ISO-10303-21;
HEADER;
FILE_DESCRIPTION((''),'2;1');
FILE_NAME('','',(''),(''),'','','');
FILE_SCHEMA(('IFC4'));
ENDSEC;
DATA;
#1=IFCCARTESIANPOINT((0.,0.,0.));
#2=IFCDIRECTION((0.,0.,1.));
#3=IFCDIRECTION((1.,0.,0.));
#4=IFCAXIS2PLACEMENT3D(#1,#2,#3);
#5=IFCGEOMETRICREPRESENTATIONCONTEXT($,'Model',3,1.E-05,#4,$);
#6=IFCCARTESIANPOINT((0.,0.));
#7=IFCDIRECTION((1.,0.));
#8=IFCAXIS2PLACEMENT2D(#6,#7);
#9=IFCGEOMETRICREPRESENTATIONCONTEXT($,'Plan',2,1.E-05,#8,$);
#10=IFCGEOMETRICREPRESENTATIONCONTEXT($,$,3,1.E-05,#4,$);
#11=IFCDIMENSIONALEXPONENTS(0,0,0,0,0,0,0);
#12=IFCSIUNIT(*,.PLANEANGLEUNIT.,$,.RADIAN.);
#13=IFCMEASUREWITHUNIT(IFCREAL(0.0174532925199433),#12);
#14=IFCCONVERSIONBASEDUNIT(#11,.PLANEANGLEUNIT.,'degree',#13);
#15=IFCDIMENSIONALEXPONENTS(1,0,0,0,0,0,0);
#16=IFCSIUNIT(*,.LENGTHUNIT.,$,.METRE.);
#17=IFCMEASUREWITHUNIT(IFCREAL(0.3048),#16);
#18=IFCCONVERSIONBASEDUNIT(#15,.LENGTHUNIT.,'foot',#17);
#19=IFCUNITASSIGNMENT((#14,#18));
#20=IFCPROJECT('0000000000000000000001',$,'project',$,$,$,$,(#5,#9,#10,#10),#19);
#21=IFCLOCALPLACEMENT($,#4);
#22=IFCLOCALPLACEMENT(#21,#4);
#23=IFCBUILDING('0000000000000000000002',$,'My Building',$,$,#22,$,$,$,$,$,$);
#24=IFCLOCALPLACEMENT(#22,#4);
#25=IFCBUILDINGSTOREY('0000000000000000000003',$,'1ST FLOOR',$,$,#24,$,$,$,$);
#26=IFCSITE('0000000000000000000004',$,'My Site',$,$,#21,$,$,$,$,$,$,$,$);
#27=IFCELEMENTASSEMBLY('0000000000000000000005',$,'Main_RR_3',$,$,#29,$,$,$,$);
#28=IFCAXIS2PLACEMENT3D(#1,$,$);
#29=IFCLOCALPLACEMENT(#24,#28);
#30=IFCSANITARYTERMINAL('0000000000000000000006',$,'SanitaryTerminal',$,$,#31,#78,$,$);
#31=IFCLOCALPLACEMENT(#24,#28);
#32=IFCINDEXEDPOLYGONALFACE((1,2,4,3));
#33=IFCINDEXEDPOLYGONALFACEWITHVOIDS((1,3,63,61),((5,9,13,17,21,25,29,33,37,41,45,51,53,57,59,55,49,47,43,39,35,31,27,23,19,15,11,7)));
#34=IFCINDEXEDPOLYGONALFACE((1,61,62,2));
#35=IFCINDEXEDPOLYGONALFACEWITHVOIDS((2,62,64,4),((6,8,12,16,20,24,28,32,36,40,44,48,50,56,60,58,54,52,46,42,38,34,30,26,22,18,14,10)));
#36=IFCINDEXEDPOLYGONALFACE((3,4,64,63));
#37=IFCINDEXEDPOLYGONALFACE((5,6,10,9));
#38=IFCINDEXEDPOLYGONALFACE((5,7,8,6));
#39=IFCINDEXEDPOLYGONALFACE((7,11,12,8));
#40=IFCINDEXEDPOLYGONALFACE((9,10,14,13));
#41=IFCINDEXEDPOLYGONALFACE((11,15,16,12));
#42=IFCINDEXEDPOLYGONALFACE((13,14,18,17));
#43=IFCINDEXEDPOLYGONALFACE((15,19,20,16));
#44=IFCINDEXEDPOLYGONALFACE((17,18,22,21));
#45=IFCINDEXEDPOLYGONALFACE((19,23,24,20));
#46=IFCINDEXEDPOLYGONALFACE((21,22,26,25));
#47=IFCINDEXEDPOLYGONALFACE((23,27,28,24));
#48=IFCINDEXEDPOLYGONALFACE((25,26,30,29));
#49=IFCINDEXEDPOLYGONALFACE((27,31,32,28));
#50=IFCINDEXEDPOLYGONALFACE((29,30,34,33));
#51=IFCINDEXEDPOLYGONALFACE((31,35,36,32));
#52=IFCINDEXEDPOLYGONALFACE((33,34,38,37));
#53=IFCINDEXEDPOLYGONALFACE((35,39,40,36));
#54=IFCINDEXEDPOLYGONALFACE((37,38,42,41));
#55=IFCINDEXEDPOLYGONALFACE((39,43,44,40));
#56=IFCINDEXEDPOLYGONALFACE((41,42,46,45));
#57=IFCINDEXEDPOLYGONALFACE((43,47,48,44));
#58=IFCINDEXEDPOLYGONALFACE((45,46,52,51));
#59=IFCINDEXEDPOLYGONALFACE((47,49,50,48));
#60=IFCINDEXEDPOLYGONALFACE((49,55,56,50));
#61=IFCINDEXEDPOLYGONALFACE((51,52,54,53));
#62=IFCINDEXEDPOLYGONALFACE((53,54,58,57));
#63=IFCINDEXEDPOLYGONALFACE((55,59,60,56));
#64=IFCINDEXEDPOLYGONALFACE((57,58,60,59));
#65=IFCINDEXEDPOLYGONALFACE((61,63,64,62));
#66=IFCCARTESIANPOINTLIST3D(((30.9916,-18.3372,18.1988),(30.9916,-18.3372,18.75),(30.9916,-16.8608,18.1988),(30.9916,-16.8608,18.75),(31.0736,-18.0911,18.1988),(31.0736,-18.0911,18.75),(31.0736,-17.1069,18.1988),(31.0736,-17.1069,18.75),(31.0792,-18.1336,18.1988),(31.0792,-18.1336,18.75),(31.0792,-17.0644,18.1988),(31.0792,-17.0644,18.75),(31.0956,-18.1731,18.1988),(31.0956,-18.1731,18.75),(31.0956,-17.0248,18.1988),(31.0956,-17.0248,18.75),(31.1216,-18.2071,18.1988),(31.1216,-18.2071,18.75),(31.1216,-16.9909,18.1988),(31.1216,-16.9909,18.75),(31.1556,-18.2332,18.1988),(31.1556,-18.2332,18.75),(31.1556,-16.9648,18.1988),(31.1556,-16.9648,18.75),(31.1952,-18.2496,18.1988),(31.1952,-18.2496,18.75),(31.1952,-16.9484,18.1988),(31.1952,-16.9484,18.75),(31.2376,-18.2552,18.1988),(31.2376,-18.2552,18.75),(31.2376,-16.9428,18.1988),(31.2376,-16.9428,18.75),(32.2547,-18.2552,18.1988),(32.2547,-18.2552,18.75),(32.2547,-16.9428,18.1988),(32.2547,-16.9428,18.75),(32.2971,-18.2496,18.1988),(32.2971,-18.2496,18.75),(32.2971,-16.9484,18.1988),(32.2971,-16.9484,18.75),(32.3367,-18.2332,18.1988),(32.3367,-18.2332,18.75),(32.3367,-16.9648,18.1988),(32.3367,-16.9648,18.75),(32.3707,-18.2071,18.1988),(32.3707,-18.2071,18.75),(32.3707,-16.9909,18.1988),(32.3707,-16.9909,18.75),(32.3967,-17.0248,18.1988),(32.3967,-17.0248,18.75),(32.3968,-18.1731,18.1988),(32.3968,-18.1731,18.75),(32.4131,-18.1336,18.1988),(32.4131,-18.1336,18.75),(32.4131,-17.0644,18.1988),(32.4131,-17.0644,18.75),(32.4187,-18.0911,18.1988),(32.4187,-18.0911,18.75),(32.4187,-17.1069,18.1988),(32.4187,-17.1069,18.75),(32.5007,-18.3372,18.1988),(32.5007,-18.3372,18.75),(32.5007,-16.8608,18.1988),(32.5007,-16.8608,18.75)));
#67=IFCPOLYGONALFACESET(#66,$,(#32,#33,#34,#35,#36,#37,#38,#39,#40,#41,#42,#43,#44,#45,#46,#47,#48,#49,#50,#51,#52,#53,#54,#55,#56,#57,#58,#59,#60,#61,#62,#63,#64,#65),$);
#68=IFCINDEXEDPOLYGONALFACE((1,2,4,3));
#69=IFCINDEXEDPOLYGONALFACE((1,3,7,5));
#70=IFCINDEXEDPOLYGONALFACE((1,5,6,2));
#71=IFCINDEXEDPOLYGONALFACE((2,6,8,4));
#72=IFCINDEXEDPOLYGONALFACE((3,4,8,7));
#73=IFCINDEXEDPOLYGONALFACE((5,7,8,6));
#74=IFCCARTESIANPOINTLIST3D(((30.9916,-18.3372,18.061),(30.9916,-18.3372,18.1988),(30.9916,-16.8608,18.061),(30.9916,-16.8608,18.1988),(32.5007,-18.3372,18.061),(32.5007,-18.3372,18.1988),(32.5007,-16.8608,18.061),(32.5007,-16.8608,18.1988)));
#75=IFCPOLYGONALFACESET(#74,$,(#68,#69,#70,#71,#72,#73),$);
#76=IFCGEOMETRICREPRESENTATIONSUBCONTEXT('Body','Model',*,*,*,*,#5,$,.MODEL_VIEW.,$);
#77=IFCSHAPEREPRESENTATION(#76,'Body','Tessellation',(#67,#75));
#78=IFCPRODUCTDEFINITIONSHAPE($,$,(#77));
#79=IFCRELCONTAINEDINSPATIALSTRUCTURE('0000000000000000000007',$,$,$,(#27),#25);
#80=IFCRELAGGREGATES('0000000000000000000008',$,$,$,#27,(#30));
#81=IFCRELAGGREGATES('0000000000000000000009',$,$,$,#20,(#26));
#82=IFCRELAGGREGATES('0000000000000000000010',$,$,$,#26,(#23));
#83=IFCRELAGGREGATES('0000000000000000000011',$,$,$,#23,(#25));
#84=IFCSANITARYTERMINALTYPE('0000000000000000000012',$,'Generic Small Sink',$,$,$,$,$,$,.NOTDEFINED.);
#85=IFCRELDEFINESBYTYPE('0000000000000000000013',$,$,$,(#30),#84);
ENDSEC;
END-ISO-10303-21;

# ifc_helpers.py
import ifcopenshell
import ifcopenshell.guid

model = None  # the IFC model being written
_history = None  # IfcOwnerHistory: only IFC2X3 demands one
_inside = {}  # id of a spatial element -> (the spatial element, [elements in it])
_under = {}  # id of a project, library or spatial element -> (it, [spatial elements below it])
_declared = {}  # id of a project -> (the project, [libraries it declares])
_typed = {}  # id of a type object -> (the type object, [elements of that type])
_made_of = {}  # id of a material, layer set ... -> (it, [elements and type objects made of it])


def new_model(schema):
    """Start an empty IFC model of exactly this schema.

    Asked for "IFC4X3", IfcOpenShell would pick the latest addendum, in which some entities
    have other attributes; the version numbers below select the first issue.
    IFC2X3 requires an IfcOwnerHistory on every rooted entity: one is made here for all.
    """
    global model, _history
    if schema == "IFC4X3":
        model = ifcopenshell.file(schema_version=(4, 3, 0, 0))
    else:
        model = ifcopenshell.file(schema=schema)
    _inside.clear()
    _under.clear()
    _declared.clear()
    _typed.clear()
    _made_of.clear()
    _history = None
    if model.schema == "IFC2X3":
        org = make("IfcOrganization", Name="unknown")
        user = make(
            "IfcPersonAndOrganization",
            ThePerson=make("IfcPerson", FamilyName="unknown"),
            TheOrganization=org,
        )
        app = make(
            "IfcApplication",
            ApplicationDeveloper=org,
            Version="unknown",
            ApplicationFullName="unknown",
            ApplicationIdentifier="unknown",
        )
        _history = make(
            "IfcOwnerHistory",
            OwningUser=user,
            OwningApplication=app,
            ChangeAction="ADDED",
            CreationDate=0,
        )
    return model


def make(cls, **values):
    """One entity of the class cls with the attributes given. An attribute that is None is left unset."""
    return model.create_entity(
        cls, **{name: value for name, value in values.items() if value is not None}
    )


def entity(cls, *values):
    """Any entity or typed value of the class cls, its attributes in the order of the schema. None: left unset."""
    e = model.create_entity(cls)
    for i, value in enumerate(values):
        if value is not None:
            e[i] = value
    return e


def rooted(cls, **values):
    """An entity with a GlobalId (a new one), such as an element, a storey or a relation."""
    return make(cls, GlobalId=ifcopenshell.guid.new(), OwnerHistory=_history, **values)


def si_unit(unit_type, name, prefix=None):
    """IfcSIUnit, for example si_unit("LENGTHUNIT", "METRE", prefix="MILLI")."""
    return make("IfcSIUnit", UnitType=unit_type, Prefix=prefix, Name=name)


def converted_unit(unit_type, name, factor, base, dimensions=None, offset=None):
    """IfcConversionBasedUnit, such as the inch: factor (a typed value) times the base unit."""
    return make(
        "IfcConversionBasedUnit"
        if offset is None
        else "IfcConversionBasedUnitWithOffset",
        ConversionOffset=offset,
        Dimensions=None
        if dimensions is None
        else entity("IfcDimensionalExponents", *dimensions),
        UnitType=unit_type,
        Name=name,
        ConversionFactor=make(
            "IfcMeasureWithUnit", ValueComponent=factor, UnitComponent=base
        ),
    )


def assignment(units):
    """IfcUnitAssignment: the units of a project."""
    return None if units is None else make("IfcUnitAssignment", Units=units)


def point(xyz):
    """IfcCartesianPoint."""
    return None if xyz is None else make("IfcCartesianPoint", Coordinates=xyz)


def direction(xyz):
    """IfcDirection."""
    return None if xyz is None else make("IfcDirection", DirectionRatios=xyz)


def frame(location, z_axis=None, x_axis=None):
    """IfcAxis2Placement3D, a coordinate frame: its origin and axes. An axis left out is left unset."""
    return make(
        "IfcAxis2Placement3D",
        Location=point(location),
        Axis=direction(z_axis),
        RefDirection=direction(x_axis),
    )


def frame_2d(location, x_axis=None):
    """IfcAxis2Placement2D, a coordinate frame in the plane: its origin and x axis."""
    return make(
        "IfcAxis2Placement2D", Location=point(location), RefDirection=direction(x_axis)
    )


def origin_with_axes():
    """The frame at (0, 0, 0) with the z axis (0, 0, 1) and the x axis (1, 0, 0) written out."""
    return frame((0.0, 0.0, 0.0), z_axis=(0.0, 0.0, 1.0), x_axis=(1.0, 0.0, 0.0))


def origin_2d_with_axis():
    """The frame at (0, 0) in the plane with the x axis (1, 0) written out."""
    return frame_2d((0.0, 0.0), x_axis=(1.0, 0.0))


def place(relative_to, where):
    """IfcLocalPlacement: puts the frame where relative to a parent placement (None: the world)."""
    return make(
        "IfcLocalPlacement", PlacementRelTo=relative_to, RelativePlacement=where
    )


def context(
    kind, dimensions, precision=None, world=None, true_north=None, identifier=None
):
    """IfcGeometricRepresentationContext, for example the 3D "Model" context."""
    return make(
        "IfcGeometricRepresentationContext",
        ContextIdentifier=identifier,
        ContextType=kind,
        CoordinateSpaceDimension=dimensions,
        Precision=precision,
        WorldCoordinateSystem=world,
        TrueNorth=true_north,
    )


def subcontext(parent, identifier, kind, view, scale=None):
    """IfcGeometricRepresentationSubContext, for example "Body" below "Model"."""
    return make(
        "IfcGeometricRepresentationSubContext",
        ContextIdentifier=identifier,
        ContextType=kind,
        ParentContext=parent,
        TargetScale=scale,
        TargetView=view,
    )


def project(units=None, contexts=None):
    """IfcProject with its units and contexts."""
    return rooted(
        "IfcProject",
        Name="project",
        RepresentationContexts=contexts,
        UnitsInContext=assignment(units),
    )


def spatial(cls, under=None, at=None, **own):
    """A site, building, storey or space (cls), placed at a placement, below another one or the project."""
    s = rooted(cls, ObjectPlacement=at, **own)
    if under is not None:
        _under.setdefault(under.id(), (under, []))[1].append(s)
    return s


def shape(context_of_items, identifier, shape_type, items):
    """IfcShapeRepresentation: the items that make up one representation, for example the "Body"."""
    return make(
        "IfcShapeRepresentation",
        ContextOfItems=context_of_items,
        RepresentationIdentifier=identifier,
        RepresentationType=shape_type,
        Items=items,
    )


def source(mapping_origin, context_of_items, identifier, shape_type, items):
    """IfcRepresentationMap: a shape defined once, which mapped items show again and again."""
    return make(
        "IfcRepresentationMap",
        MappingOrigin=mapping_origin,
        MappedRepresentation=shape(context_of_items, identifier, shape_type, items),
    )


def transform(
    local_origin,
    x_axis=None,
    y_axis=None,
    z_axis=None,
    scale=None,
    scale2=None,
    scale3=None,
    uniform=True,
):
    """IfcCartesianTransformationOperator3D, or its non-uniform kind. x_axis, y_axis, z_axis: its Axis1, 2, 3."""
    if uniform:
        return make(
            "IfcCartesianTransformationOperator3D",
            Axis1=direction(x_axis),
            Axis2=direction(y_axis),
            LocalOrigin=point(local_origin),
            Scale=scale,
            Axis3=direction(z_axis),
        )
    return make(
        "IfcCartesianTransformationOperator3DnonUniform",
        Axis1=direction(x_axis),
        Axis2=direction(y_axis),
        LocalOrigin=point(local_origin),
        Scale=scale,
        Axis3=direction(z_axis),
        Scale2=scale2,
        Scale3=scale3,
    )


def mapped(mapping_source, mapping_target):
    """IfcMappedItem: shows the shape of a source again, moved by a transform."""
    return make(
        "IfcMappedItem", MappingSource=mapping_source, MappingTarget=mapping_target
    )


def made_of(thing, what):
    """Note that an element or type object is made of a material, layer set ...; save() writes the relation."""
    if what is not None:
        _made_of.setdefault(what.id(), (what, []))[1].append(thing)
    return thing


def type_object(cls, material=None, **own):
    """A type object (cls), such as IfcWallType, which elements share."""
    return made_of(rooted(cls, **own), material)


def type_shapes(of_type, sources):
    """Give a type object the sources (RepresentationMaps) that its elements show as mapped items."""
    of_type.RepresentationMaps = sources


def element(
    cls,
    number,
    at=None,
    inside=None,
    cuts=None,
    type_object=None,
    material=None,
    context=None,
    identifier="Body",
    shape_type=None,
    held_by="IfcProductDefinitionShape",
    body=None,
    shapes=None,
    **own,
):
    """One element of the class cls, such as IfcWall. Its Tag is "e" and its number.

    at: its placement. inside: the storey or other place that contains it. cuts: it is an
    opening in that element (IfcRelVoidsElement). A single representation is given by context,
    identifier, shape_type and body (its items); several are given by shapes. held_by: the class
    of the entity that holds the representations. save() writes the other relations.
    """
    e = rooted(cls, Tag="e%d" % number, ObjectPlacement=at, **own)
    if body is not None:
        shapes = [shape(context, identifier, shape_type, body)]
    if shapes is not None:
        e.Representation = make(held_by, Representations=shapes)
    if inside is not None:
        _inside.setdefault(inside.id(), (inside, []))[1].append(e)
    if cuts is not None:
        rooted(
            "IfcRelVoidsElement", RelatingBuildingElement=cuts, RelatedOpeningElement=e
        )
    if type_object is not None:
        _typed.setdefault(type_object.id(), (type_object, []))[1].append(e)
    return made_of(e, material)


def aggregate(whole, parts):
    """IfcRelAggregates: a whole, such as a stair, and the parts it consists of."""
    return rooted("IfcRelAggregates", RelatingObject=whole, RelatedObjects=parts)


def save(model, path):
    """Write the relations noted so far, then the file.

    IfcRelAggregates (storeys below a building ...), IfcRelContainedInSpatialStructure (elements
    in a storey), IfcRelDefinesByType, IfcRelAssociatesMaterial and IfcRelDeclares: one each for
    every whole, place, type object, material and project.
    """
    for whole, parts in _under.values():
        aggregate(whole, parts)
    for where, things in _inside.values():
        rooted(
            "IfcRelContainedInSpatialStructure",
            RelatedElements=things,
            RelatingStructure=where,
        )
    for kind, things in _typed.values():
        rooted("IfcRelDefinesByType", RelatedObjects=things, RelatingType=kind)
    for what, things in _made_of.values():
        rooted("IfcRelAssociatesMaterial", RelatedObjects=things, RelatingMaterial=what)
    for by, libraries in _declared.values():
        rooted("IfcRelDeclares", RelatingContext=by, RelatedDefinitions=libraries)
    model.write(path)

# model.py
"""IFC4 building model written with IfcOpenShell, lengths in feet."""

from ifc_helpers import new_model, entity, si_unit, converted_unit, frame, origin_with_axes, origin_2d_with_axis, place, context, subcontext, project, spatial, source, transform, mapped, type_object, type_shapes, element, aggregate, save


model = new_model("IFC4")

# Units and contexts
model_context = context("Model", 3, precision=1e-05, world=origin_with_axes())
plan_context = context("Plan", 2, precision=1e-05, world=origin_2d_with_axis())
context_of_model = context(None, 3, precision=1e-05, world=origin_with_axes())
body_context_1 = subcontext(model_context, "Body", "Model", "MODEL_VIEW")
ifc_project = project(units=[converted_unit("PLANEANGLEUNIT", "degree", entity("IfcReal", 0.0174532925199433), si_unit("PLANEANGLEUNIT", "RADIAN"), dimensions=[0, 0, 0, 0, 0, 0, 0]), converted_unit("LENGTHUNIT", "foot", entity("IfcReal", 0.3048), si_unit("LENGTHUNIT", "METRE"), dimensions=[1, 0, 0, 0, 0, 0, 0])], contexts=[model_context, plan_context, context_of_model, context_of_model])

# Site, building, storey
site_placement = place(None, origin_with_axes())
site = spatial("IfcSite", under=ifc_project, at=site_placement, Name="My Site")
building_placement = place(site_placement, origin_with_axes())
building = spatial("IfcBuilding", under=site, at=building_placement, Name="My Building")
storey_placement = place(building_placement, origin_with_axes())
storey = spatial("IfcBuildingStorey", under=building, at=storey_placement, Name="1ST FLOOR")

# Element assembly, sanitary terminal
assembly_placement = place(storey_placement, frame((198.1085, -500.4459, 5.5), z_axis=(0.0, 0.0, 1.0), x_axis=(-1.0, 0.0, 0.0)))
assembly = element("IfcElementAssembly", 1, at=assembly_placement, inside=storey, Name="Main_RR_3")
sanitary_terminal_type_1 = type_object("IfcSanitaryTerminalType", Name="Generic Small Sink", PredefinedType="NOTDEFINED")
shared_indexed_poly_curve = entity("IfcIndexedPolyCurve", entity("IfcCartesianPointList2D", [[0.0, 0.0], [1.4764, 0.0], [1.4764, 1.5092], [0.0, 1.5092]]), [entity("IfcLineIndex", [1, 2, 3, 4, 1])])
shared_shape_1 = source(origin_with_axes(), body_context_1, "Body", "SweptSolid", [
    entity("IfcExtrudedAreaSolid", entity("IfcArbitraryProfileDefWithVoids", "AREA", None, shared_indexed_poly_curve, [entity("IfcIndexedPolyCurve", entity("IfcCartesianPointList2D", [[0.082, 0.2461], [0.1301, 0.1301], [0.2461, 0.082], [1.2303, 0.082], [1.3463, 0.1301], [1.3944, 0.2461], [1.3944, 1.2631], [1.3463, 1.3791], [1.2303, 1.4272], [0.2461, 1.4272], [0.1301, 1.3791], [0.082, 1.2631]]), [entity("IfcLineIndex", [12, 1]), entity("IfcArcIndex", [1, 2, 3]), entity("IfcLineIndex", [3, 4]), entity("IfcArcIndex", [4, 5, 6]), entity("IfcLineIndex", [6, 7]), entity("IfcArcIndex", [7, 8, 9]), entity("IfcLineIndex", [9, 10]), entity("IfcArcIndex", [10, 11, 12]), entity("IfcLineIndex", [12, 1])])]), entity("IfcAxis2Placement3D", entity("IfcCartesianPoint", [-0.7382, -1.5092, 0.1378]), entity("IfcDirection", [0.0, 0.0, 1.0]), entity("IfcDirection", [1.0, 0.0, 0.0])), entity("IfcDirection", [0.0, 0.0, 1.0]), 0.5512),
    entity("IfcExtrudedAreaSolid", entity("IfcArbitraryClosedProfileDef", "AREA", None, shared_indexed_poly_curve), entity("IfcAxis2Placement3D", entity("IfcCartesianPoint", [-0.7382, -1.5092, 0.0]), entity("IfcDirection", [0.0, 0.0, 1.0]), entity("IfcDirection", [1.0, 0.0, 0.0])), entity("IfcDirection", [0.0, 0.0, 1.0]), 0.1378),
])
type_shapes(sanitary_terminal_type_1, [shared_shape_1])
sanitary_terminal_1_placement = place(assembly_placement, frame((167.1168, -482.847, 12.561), z_axis=(0.0, 0.0, 1.0), x_axis=(0.0, -1.0, 0.0)))
sanitary_terminal_1 = element("IfcSanitaryTerminal", 2, at=sanitary_terminal_1_placement, type_object=sanitary_terminal_type_1, Name="SanitaryTerminal", context=body_context_1, shape_type="MappedRepresentation", body=[
    mapped(shared_shape_1, transform((0.0, 0.0, 0.0), x_axis=(1.0, 0.0, 0.0), y_axis=(0.0, 1.0, 0.0), z_axis=(0.0, 0.0, 1.0), scale=1.0)),
])
aggregate(assembly, [sanitary_terminal_1])

save(model, "model.ifc")
